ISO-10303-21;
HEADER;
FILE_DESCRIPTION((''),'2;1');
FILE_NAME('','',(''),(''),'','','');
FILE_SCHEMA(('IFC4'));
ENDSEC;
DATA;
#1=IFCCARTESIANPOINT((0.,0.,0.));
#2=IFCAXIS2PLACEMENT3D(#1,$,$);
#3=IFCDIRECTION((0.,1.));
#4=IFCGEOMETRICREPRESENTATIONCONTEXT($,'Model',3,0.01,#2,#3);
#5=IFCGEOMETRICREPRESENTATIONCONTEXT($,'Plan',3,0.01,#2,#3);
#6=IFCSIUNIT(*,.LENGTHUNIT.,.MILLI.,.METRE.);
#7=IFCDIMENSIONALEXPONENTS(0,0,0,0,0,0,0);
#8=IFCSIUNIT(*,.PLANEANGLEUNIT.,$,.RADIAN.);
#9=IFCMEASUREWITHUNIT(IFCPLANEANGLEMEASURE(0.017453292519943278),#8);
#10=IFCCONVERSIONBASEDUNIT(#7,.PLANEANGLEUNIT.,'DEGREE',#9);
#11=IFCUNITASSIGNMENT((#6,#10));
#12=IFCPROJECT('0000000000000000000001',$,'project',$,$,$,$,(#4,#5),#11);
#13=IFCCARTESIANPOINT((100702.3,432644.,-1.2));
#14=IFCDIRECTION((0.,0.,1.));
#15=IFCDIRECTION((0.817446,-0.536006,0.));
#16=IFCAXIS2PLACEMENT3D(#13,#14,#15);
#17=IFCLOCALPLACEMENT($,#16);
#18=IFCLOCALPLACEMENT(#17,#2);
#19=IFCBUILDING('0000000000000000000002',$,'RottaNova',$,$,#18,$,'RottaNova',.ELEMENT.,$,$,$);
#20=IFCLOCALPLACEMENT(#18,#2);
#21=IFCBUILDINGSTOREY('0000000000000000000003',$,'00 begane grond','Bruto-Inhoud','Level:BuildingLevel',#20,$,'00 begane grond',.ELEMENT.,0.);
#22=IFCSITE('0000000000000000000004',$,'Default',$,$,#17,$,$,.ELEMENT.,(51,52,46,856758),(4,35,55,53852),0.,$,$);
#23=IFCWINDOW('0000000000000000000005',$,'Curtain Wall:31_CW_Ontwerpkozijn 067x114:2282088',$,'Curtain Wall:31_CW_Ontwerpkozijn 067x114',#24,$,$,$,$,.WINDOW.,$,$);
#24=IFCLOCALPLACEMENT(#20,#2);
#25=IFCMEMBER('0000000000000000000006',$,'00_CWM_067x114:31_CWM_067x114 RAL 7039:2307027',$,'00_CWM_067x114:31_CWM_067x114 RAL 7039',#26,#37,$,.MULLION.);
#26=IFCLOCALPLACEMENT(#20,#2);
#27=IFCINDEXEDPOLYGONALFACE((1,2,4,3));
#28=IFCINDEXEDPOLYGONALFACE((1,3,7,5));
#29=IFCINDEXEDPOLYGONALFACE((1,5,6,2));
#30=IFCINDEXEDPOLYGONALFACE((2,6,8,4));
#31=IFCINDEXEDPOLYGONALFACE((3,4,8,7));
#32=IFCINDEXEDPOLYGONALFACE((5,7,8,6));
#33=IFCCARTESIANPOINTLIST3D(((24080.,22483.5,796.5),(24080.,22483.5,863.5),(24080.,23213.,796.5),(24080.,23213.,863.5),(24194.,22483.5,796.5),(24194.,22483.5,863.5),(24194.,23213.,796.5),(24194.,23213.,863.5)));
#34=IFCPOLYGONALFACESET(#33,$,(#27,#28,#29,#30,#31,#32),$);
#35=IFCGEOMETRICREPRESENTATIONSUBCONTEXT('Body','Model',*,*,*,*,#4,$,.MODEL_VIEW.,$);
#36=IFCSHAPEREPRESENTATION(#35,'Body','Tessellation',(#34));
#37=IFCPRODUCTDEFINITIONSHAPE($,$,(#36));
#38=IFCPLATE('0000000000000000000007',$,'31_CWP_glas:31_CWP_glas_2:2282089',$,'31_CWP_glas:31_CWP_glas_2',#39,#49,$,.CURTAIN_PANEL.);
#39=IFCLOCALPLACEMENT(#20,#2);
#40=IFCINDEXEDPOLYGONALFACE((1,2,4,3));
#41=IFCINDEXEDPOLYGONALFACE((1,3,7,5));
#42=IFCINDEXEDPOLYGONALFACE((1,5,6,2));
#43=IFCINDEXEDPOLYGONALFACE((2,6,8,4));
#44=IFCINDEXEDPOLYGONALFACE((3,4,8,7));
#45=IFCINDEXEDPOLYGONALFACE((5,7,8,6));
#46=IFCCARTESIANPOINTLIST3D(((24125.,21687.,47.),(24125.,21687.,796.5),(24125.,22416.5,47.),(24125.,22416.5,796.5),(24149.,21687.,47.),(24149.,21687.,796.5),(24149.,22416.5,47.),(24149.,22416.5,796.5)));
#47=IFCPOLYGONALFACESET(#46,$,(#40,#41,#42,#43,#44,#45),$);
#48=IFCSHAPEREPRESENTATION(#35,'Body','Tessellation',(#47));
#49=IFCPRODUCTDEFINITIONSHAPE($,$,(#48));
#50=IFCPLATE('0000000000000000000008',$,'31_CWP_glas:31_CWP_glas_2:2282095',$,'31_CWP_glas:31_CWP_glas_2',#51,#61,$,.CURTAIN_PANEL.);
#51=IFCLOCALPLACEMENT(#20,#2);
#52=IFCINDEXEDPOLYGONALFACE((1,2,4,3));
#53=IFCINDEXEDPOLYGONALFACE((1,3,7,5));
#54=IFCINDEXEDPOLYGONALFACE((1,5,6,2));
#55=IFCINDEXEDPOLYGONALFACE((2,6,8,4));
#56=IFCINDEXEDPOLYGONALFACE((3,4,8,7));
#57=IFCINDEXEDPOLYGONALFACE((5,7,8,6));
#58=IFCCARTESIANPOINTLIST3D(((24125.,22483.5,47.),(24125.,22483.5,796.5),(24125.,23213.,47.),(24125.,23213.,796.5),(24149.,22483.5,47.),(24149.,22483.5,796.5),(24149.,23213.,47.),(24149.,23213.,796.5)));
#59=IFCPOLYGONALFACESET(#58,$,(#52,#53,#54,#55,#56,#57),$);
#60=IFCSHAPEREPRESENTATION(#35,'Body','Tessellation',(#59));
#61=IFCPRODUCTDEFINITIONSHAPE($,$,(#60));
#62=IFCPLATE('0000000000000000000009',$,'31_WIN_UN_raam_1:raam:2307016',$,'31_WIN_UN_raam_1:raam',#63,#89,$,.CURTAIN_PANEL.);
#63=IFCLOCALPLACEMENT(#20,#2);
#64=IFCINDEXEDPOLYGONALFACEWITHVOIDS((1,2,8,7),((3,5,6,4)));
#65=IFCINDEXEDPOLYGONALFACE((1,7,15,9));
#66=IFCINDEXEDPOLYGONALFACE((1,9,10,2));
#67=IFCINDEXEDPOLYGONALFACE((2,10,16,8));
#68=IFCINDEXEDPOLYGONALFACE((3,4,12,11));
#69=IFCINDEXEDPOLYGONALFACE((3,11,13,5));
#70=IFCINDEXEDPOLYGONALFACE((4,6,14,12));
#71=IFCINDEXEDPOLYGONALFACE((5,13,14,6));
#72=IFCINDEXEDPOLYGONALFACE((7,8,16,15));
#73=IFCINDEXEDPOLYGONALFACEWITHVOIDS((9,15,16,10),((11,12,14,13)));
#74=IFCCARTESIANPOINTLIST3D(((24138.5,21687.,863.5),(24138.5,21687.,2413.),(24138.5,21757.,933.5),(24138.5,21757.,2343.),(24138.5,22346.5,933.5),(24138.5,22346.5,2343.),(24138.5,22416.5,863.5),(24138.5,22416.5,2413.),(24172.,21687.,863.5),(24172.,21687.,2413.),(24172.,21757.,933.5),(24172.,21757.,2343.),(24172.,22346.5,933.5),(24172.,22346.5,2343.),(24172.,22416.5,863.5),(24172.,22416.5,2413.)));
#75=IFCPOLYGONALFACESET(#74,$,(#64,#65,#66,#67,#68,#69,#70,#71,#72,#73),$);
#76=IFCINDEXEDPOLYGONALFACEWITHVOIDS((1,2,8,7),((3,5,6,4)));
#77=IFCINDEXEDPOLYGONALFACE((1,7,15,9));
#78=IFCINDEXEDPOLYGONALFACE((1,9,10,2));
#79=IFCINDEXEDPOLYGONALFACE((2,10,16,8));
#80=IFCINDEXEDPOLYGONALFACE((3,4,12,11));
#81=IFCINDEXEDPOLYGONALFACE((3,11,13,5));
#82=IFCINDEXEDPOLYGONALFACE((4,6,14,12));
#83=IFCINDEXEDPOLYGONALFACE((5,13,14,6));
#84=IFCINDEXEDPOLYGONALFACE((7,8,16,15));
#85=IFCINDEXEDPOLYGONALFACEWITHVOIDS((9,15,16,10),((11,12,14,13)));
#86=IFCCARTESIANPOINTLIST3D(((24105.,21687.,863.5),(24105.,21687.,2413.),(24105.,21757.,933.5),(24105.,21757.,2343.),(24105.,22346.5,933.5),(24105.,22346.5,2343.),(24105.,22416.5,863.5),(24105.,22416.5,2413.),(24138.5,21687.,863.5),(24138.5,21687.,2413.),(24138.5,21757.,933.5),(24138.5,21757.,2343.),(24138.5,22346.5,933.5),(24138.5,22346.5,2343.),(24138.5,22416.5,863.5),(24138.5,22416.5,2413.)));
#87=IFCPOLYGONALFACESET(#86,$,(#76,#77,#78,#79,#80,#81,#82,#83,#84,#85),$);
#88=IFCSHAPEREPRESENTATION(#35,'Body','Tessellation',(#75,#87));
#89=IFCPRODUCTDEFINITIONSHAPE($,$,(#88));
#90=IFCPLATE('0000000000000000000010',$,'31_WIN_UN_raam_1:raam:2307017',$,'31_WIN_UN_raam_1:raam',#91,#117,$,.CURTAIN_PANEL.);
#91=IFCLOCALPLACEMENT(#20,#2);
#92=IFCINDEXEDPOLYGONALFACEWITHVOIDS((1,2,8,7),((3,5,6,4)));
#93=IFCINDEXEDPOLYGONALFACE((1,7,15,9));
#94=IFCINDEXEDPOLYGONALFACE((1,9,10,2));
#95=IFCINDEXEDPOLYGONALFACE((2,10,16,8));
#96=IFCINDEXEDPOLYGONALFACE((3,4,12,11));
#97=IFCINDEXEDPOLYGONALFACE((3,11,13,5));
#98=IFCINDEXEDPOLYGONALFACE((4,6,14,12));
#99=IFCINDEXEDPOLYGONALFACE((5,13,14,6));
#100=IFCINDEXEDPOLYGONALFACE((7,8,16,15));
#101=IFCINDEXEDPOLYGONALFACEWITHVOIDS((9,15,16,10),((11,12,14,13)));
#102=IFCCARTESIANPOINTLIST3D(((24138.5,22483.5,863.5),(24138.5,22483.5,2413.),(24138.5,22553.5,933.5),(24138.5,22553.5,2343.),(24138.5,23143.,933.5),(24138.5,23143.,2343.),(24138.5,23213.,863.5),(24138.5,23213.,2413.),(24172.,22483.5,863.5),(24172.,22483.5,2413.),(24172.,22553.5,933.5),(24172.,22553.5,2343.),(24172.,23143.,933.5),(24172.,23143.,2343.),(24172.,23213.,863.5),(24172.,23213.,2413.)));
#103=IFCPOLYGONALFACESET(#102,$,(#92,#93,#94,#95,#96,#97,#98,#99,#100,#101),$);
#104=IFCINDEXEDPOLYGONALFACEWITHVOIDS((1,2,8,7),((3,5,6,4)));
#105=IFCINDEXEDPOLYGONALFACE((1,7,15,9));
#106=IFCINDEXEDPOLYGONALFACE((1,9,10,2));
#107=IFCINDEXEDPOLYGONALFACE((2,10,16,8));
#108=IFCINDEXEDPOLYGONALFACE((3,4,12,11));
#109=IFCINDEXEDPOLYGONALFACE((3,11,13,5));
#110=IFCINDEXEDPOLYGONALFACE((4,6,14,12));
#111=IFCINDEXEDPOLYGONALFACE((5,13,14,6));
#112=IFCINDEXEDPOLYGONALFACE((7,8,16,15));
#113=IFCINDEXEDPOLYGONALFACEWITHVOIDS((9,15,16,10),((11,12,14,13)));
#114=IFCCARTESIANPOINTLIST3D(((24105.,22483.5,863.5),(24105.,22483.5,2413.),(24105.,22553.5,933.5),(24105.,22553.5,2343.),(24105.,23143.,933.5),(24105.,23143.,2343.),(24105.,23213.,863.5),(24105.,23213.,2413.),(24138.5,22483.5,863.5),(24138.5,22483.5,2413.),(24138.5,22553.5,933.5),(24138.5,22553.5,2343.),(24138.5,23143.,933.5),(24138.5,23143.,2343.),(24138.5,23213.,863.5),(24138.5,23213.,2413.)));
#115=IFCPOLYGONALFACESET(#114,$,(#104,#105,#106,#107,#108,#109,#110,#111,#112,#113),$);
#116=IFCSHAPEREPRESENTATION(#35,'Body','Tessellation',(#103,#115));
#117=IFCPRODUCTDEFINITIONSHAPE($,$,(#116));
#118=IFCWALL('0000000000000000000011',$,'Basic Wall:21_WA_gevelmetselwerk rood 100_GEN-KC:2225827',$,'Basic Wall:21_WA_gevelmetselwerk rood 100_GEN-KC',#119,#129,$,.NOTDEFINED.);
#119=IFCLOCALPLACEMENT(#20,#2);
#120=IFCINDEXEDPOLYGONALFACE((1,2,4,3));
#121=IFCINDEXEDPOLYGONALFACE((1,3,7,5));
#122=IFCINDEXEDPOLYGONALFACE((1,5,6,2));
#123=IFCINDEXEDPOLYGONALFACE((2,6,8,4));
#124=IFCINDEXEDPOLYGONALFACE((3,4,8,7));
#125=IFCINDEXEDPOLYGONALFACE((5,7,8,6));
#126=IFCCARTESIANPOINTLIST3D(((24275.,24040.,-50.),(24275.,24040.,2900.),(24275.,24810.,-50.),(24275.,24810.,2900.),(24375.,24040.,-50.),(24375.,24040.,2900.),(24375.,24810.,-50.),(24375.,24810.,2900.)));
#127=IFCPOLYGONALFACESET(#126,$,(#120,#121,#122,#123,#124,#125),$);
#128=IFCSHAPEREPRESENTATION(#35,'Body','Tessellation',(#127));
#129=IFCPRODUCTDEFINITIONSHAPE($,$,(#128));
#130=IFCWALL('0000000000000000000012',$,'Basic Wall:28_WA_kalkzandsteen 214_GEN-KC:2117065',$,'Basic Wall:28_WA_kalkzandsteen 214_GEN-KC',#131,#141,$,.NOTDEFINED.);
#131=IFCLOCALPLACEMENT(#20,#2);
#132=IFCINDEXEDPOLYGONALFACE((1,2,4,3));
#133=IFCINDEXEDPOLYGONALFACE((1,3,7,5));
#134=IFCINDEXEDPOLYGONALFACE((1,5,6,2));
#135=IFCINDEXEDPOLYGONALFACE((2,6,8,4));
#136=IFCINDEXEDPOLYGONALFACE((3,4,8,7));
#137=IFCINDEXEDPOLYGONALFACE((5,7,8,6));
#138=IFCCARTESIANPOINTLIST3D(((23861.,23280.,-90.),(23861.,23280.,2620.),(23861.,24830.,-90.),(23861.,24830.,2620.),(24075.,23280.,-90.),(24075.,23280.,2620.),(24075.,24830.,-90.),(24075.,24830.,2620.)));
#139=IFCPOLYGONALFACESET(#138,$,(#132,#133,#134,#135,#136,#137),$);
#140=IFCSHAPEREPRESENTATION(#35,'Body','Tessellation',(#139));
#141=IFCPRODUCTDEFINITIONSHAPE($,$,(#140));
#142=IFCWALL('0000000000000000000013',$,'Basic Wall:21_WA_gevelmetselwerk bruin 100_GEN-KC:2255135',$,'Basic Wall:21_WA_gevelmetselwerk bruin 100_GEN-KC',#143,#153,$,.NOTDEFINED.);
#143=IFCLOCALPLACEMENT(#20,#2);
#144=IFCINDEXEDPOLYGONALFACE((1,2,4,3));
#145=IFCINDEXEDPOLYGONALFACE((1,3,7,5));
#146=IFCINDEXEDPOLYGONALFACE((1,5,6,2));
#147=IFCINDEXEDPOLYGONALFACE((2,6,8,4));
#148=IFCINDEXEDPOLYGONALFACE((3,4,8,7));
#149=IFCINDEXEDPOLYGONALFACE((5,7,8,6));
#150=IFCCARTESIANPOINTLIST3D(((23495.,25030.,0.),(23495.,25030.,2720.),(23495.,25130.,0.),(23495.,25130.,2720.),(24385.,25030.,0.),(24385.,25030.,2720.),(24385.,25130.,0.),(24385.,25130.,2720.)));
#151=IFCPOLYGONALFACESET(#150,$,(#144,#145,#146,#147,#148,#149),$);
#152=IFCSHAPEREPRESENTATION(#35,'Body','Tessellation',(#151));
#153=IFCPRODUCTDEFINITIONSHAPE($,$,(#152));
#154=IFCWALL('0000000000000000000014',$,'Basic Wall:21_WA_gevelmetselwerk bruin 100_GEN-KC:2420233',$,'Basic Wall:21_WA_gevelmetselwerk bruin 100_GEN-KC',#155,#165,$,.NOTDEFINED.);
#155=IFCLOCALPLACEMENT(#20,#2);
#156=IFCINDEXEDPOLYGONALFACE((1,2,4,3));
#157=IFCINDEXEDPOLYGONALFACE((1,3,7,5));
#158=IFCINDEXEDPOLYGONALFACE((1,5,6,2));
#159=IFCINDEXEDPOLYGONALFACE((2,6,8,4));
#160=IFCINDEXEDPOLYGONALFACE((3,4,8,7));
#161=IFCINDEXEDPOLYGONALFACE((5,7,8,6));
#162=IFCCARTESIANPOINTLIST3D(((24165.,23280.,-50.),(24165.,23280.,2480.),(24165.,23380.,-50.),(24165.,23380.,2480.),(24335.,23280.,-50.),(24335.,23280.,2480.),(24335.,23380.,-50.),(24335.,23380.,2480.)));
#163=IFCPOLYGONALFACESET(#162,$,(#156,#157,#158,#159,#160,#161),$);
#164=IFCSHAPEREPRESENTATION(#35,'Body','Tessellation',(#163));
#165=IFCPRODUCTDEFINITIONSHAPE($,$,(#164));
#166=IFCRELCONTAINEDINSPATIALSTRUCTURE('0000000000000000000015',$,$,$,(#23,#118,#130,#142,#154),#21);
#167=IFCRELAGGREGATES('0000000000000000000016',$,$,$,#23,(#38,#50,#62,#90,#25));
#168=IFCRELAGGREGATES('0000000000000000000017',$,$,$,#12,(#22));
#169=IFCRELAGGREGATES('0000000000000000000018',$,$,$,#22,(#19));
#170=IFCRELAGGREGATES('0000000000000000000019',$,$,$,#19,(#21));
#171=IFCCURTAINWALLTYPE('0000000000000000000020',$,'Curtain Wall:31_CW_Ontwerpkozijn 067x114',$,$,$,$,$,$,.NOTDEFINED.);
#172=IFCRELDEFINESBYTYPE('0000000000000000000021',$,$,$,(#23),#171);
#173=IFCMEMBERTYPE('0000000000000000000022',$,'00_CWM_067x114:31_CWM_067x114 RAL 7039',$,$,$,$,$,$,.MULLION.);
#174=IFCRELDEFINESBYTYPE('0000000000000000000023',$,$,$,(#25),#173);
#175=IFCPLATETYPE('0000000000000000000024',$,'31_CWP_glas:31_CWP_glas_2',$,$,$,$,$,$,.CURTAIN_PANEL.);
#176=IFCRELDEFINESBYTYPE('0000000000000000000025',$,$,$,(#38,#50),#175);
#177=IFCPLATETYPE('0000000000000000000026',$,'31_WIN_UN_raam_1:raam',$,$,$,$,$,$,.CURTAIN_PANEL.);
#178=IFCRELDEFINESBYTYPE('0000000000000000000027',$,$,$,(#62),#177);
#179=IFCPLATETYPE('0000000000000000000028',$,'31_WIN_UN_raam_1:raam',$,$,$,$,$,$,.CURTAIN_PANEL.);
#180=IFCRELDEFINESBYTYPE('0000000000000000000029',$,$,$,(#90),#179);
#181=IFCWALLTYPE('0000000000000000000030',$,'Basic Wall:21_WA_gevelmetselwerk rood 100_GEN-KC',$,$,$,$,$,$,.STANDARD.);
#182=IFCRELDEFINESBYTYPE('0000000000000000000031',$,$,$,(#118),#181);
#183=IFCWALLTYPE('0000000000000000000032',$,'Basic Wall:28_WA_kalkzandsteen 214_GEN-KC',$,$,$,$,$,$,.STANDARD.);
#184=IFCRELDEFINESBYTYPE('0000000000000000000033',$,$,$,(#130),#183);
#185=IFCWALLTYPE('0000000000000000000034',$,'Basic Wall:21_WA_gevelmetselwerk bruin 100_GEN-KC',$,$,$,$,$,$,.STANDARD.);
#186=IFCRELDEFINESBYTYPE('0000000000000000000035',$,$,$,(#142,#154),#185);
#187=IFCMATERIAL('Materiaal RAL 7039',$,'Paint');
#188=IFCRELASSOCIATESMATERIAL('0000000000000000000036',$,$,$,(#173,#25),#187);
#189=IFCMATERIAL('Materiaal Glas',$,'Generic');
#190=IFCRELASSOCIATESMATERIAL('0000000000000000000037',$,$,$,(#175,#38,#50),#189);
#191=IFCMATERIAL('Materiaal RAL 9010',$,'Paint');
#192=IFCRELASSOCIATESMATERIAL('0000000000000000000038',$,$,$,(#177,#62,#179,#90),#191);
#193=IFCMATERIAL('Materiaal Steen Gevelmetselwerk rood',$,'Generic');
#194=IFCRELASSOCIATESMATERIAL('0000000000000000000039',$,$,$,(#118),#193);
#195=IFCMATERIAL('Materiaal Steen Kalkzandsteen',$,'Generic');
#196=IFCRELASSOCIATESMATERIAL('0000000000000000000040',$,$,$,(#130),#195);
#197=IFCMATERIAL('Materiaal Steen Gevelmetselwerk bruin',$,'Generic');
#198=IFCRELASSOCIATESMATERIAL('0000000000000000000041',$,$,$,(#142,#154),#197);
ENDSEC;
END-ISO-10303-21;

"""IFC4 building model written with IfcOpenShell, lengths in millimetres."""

from ifc_helpers import new_model, entity, si_unit, converted_unit, direction, frame, origin, place, context, subcontext, project, spatial, indexed_curve, outline, extrude, source, transform, mapped, material, type_object, type_shapes, element, aggregate, save


model = new_model("IFC4")

# Units and contexts
model_context = context("Model", 3, precision=0.01, world=origin(), true_north=direction((0.0, 1.0)))
plan_context = context("Plan", 3, precision=0.01, world=origin(), true_north=direction((0.0, 1.0)))
body_context = subcontext(model_context, "Body", "Model", "MODEL_VIEW")
ifc_project = project(units=[si_unit("LENGTHUNIT", "METRE", prefix="MILLI"), converted_unit("PLANEANGLEUNIT", "DEGREE", entity("IfcPlaneAngleMeasure", 0.017453292519943278), si_unit("PLANEANGLEUNIT", "RADIAN"), dimensions=[0, 0, 0, 0, 0, 0, 0])], contexts=[model_context, plan_context])

# Site, building, storey
site_placement = place(None, frame((100702.3, 432644.0, -1.2), z_axis=(0.0, 0.0, 1.0), x_axis=(0.817446, -0.536006, 0.0)))
site = spatial("IfcSite", under=ifc_project, at=site_placement, Name="Default", CompositionType="ELEMENT", RefLatitude=(51, 52, 46, 856758), RefLongitude=(4, 35, 55, 53852), RefElevation=0.0)
building_placement = place(site_placement, origin())
building = spatial("IfcBuilding", under=site, at=building_placement, Name="RottaNova", LongName="RottaNova", CompositionType="ELEMENT")
storey_placement = place(building_placement, origin())
storey = spatial("IfcBuildingStorey", under=building, at=storey_placement, Name="00 begane grond", Description="Bruto-Inhoud", ObjectType="Level:BuildingLevel", LongName="00 begane grond", CompositionType="ELEMENT", Elevation=0.0)

# Window, member, plates
curtain_wall_type = type_object("IfcCurtainWallType", Name="Curtain Wall:31_CW_Ontwerpkozijn 067x114", PredefinedType="NOTDEFINED")
window_placement = place(storey_placement, origin())
window = element("IfcWindow", 1, at=window_placement, inside=storey, type_object=curtain_wall_type, Name="Curtain Wall:31_CW_Ontwerpkozijn 067x114:2282088", ObjectType="Curtain Wall:31_CW_Ontwerpkozijn 067x114", PredefinedType="WINDOW")
ifc_material_1 = material(Name="Materiaal RAL 7039", Category="Paint")
member_type_1 = type_object("IfcMemberType", Name="00_CWM_067x114:31_CWM_067x114 RAL 7039", PredefinedType="MULLION", material=ifc_material_1)
shared_shape_1 = source(origin(), body_context, "Body", "SweptSolid", [
    extrude(outline(indexed_curve([(-33.5, -57.0), (33.5, -57.0), (33.5, 57.0), (-33.5, 57.0), (-33.5, -57.0)], self_intersect=False)), frame((0.0, 57.0, -729.5), z_axis=(0.0, 0.0, 1.0), x_axis=(-1.0, 0.0, 0.0)), (0.0, 0.0, 1.0), 729.5),
])
type_shapes(member_type_1, [shared_shape_1])
member_1_placement = place(window_placement, frame((24080.0, 23213.0, 830.0), z_axis=(0.0, 1.0, 0.0), x_axis=(0.0, 0.0, 1.0)))
member_1 = element("IfcMember", 2, at=member_1_placement, type_object=member_type_1, material=ifc_material_1, Name="00_CWM_067x114:31_CWM_067x114 RAL 7039:2307027", ObjectType="00_CWM_067x114:31_CWM_067x114 RAL 7039", PredefinedType="MULLION", context=body_context, shape_type="MappedRepresentation", body=[
    mapped(shared_shape_1, transform((0.0, 0.0, 0.0), scale=1.0)),
])
ifc_material_2 = material(Name="Materiaal Glas", Category="Generic")
plate_type_1 = type_object("IfcPlateType", Name="31_CWP_glas:31_CWP_glas_2", PredefinedType="CURTAIN_PANEL", material=ifc_material_2)
shared_shape_2 = source(origin(), body_context, "Body", "SweptSolid", [
    extrude(outline(indexed_curve([(-12.0, -364.7), (12.0, -364.7), (12.0, 364.7), (-12.0, 364.7), (-12.0, -364.7)], self_intersect=False)), frame((0.0, -57.0, 0.0), z_axis=(0.0, 0.0, 1.0), x_axis=(0.0, 1.0, 0.0)), (0.0, 0.0, 1.0), 749.5),
])
type_shapes(plate_type_1, [shared_shape_2])
plate_1_placement = place(window_placement, frame((24080.0, 22051.7, 47.0), z_axis=(0.0, 0.0, 1.0), x_axis=(0.0, 1.0, 0.0)))
plate_1 = element("IfcPlate", 3, at=plate_1_placement, type_object=plate_type_1, material=ifc_material_2, Name="31_CWP_glas:31_CWP_glas_2:2282089", ObjectType="31_CWP_glas:31_CWP_glas_2", PredefinedType="CURTAIN_PANEL", context=body_context, shape_type="MappedRepresentation", body=[
    mapped(shared_shape_2, transform((0.0, 0.0, 0.0), scale=1.0)),
])
plate_2_placement = place(window_placement, frame((24080.0, 22848.2, 47.0), z_axis=(0.0, 0.0, 1.0), x_axis=(0.0, 1.0, 0.0)))
plate_2 = element("IfcPlate", 4, at=plate_2_placement, type_object=plate_type_1, material=ifc_material_2, Name="31_CWP_glas:31_CWP_glas_2:2282095", ObjectType="31_CWP_glas:31_CWP_glas_2", PredefinedType="CURTAIN_PANEL", context=body_context, shape_type="MappedRepresentation", body=[
    mapped(shared_shape_2, transform((0.0, 0.0, 0.0), scale=1.0)),
])
ifc_material_3 = material(Name="Materiaal RAL 9010", Category="Paint")
plate_type_2 = type_object("IfcPlateType", Name="31_WIN_UN_raam_1:raam", PredefinedType="CURTAIN_PANEL", material=ifc_material_3)
shared_shape_3 = source(origin(), body_context, "Body", "SweptSolid", [
    extrude(outline(indexed_curve([(-364.7, -774.7), (364.7, -774.7), (364.7, 774.7), (-364.7, 774.7), (-364.7, -774.7)], self_intersect=False), holes=[indexed_curve([(-294.7, 704.7), (294.7, 704.7), (294.7, -704.8), (-294.7, -704.8), (-294.7, 704.7)], self_intersect=False)]), frame((0.0, -92.0, 774.8), z_axis=(0.0, 1.0, 0.0), x_axis=(1.0, 0.0, 0.0)), (0.0, 0.0, 1.0), 33.5),
    extrude(outline(indexed_curve([(-364.7, -774.7), (364.7, -774.7), (364.7, 774.7), (-364.7, 774.7), (-364.7, -774.7)], self_intersect=False), holes=[indexed_curve([(-294.7, 704.7), (294.7, 704.7), (294.7, -704.8), (-294.7, -704.8), (-294.7, 704.7)], self_intersect=False)]), frame((0.0, -58.5, 774.8), z_axis=(0.0, 1.0, 0.0), x_axis=(1.0, 0.0, 0.0)), (0.0, 0.0, 1.0), 33.5),
])
type_shapes(plate_type_2, [shared_shape_3])
plate_3_placement = place(window_placement, frame((24080.0, 22051.7, 863.5), z_axis=(0.0, 0.0, 1.0), x_axis=(0.0, 1.0, 0.0)))
plate_3 = element("IfcPlate", 5, at=plate_3_placement, type_object=plate_type_2, material=ifc_material_3, Name="31_WIN_UN_raam_1:raam:2307016", ObjectType="31_WIN_UN_raam_1:raam", PredefinedType="CURTAIN_PANEL", context=body_context, shape_type="MappedRepresentation", body=[
    mapped(shared_shape_3, transform((0.0, 0.0, 0.0), scale=1.0)),
])
plate_type_3 = type_object("IfcPlateType", Name="31_WIN_UN_raam_1:raam", PredefinedType="CURTAIN_PANEL", material=ifc_material_3)
shared_shape_4 = source(origin(), body_context, "Body", "SweptSolid", [
    extrude(outline(indexed_curve([(-364.7, -774.7), (364.7, -774.7), (364.7, 774.7), (-364.7, 774.7), (-364.7, -774.7)], self_intersect=False), holes=[indexed_curve([(-294.7, 704.7), (294.7, 704.7), (294.7, -704.8), (-294.7, -704.8), (-294.7, 704.7)], self_intersect=False)]), frame((0.0, -92.0, 774.8), z_axis=(0.0, 1.0, 0.0), x_axis=(1.0, 0.0, 0.0)), (0.0, 0.0, 1.0), 33.5),
    extrude(outline(indexed_curve([(-364.7, -774.7), (364.7, -774.7), (364.7, 774.7), (-364.7, 774.7), (-364.7, -774.7)], self_intersect=False), holes=[indexed_curve([(-294.7, 704.7), (294.7, 704.7), (294.7, -704.8), (-294.7, -704.8), (-294.7, 704.7)], self_intersect=False)]), frame((0.0, -58.5, 774.8), z_axis=(0.0, 1.0, 0.0), x_axis=(1.0, 0.0, 0.0)), (0.0, 0.0, 1.0), 33.5),
])
type_shapes(plate_type_3, [shared_shape_4])
plate_4_placement = place(window_placement, frame((24080.0, 22848.2, 863.5), z_axis=(0.0, 0.0, 1.0), x_axis=(0.0, 1.0, 0.0)))
plate_4 = element("IfcPlate", 6, at=plate_4_placement, type_object=plate_type_3, material=ifc_material_3, Name="31_WIN_UN_raam_1:raam:2307017", ObjectType="31_WIN_UN_raam_1:raam", PredefinedType="CURTAIN_PANEL", context=body_context, shape_type="MappedRepresentation", body=[
    mapped(shared_shape_4, transform((0.0, 0.0, 0.0), scale=1.0)),
])
aggregate(window, [plate_1, plate_2, plate_3, plate_4, member_1])

# Walls
ifc_material_4 = material(Name="Materiaal Steen Gevelmetselwerk rood", Category="Generic")
wall_type_1 = type_object("IfcWallType", Name="Basic Wall:21_WA_gevelmetselwerk rood 100_GEN-KC", PredefinedType="STANDARD")
wall_1_placement = place(storey_placement, frame((24325.0, 24810.0, -50.0), z_axis=(0.0, 0.0, 1.0), x_axis=(0.0, -1.0, 0.0)))
element("IfcWall", 7, at=wall_1_placement, inside=storey, type_object=wall_type_1, material=ifc_material_4, Name="Basic Wall:21_WA_gevelmetselwerk rood 100_GEN-KC:2225827", ObjectType="Basic Wall:21_WA_gevelmetselwerk rood 100_GEN-KC", PredefinedType="NOTDEFINED", context=body_context, shape_type="SweptSolid", body=[
    extrude(outline(indexed_curve([(770.0, 50.0), (0.0, 50.0), (0.0, -50.0), (770.0, -50.0), (770.0, 50.0)], self_intersect=False)), origin(), (0.0, 0.0, 1.0), 2950.0),
])
ifc_material_5 = material(Name="Materiaal Steen Kalkzandsteen", Category="Generic")
wall_type_2 = type_object("IfcWallType", Name="Basic Wall:28_WA_kalkzandsteen 214_GEN-KC", PredefinedType="STANDARD")
wall_2_placement = place(storey_placement, frame((23968.0, 24830.0, -90.0), z_axis=(0.0, 0.0, 1.0), x_axis=(0.0, -1.0, 0.0)))
element("IfcWall", 8, at=wall_2_placement, inside=storey, type_object=wall_type_2, material=ifc_material_5, Name="Basic Wall:28_WA_kalkzandsteen 214_GEN-KC:2117065", ObjectType="Basic Wall:28_WA_kalkzandsteen 214_GEN-KC", PredefinedType="NOTDEFINED", context=body_context, shape_type="SweptSolid", body=[
    extrude(outline(indexed_curve([(1550.0, 107.0), (0.0, 107.0), (0.0, -107.0), (1550.0, -107.0), (1550.0, 107.0)], self_intersect=False)), origin(), (0.0, 0.0, 1.0), 2710.0),
])
ifc_material_6 = material(Name="Materiaal Steen Gevelmetselwerk bruin", Category="Generic")
wall_type_3 = type_object("IfcWallType", Name="Basic Wall:21_WA_gevelmetselwerk bruin 100_GEN-KC", PredefinedType="STANDARD")
wall_3_placement = place(storey_placement, frame((24385.0, 25080.0, 0.0), z_axis=(0.0, 0.0, 1.0), x_axis=(-1.0, 0.0, 0.0)))
element("IfcWall", 9, at=wall_3_placement, inside=storey, type_object=wall_type_3, material=ifc_material_6, Name="Basic Wall:21_WA_gevelmetselwerk bruin 100_GEN-KC:2255135", ObjectType="Basic Wall:21_WA_gevelmetselwerk bruin 100_GEN-KC", PredefinedType="NOTDEFINED", context=body_context, shape_type="SweptSolid", body=[
    extrude(outline(indexed_curve([(890.0, 50.0), (0.0, 50.0), (0.0, -50.0), (890.0, -50.0), (890.0, 50.0)], self_intersect=False)), origin(), (0.0, 0.0, 1.0), 2720.0),
])
wall_4_placement = place(storey_placement, frame((24335.0, 23330.0, -50.0), z_axis=(0.0, 0.0, 1.0), x_axis=(-1.0, 0.0, 0.0)))
element("IfcWall", 10, at=wall_4_placement, inside=storey, type_object=wall_type_3, material=ifc_material_6, Name="Basic Wall:21_WA_gevelmetselwerk bruin 100_GEN-KC:2420233", ObjectType="Basic Wall:21_WA_gevelmetselwerk bruin 100_GEN-KC", PredefinedType="NOTDEFINED", context=body_context, shape_type="SweptSolid", body=[
    extrude(outline(indexed_curve([(170.0, 50.0), (0.0, 50.0), (0.0, -50.0), (170.0, -50.0), (170.0, 50.0)], self_intersect=False)), origin(), (0.0, 0.0, 1.0), 2530.0),
])

save(model, "model.ifc")
